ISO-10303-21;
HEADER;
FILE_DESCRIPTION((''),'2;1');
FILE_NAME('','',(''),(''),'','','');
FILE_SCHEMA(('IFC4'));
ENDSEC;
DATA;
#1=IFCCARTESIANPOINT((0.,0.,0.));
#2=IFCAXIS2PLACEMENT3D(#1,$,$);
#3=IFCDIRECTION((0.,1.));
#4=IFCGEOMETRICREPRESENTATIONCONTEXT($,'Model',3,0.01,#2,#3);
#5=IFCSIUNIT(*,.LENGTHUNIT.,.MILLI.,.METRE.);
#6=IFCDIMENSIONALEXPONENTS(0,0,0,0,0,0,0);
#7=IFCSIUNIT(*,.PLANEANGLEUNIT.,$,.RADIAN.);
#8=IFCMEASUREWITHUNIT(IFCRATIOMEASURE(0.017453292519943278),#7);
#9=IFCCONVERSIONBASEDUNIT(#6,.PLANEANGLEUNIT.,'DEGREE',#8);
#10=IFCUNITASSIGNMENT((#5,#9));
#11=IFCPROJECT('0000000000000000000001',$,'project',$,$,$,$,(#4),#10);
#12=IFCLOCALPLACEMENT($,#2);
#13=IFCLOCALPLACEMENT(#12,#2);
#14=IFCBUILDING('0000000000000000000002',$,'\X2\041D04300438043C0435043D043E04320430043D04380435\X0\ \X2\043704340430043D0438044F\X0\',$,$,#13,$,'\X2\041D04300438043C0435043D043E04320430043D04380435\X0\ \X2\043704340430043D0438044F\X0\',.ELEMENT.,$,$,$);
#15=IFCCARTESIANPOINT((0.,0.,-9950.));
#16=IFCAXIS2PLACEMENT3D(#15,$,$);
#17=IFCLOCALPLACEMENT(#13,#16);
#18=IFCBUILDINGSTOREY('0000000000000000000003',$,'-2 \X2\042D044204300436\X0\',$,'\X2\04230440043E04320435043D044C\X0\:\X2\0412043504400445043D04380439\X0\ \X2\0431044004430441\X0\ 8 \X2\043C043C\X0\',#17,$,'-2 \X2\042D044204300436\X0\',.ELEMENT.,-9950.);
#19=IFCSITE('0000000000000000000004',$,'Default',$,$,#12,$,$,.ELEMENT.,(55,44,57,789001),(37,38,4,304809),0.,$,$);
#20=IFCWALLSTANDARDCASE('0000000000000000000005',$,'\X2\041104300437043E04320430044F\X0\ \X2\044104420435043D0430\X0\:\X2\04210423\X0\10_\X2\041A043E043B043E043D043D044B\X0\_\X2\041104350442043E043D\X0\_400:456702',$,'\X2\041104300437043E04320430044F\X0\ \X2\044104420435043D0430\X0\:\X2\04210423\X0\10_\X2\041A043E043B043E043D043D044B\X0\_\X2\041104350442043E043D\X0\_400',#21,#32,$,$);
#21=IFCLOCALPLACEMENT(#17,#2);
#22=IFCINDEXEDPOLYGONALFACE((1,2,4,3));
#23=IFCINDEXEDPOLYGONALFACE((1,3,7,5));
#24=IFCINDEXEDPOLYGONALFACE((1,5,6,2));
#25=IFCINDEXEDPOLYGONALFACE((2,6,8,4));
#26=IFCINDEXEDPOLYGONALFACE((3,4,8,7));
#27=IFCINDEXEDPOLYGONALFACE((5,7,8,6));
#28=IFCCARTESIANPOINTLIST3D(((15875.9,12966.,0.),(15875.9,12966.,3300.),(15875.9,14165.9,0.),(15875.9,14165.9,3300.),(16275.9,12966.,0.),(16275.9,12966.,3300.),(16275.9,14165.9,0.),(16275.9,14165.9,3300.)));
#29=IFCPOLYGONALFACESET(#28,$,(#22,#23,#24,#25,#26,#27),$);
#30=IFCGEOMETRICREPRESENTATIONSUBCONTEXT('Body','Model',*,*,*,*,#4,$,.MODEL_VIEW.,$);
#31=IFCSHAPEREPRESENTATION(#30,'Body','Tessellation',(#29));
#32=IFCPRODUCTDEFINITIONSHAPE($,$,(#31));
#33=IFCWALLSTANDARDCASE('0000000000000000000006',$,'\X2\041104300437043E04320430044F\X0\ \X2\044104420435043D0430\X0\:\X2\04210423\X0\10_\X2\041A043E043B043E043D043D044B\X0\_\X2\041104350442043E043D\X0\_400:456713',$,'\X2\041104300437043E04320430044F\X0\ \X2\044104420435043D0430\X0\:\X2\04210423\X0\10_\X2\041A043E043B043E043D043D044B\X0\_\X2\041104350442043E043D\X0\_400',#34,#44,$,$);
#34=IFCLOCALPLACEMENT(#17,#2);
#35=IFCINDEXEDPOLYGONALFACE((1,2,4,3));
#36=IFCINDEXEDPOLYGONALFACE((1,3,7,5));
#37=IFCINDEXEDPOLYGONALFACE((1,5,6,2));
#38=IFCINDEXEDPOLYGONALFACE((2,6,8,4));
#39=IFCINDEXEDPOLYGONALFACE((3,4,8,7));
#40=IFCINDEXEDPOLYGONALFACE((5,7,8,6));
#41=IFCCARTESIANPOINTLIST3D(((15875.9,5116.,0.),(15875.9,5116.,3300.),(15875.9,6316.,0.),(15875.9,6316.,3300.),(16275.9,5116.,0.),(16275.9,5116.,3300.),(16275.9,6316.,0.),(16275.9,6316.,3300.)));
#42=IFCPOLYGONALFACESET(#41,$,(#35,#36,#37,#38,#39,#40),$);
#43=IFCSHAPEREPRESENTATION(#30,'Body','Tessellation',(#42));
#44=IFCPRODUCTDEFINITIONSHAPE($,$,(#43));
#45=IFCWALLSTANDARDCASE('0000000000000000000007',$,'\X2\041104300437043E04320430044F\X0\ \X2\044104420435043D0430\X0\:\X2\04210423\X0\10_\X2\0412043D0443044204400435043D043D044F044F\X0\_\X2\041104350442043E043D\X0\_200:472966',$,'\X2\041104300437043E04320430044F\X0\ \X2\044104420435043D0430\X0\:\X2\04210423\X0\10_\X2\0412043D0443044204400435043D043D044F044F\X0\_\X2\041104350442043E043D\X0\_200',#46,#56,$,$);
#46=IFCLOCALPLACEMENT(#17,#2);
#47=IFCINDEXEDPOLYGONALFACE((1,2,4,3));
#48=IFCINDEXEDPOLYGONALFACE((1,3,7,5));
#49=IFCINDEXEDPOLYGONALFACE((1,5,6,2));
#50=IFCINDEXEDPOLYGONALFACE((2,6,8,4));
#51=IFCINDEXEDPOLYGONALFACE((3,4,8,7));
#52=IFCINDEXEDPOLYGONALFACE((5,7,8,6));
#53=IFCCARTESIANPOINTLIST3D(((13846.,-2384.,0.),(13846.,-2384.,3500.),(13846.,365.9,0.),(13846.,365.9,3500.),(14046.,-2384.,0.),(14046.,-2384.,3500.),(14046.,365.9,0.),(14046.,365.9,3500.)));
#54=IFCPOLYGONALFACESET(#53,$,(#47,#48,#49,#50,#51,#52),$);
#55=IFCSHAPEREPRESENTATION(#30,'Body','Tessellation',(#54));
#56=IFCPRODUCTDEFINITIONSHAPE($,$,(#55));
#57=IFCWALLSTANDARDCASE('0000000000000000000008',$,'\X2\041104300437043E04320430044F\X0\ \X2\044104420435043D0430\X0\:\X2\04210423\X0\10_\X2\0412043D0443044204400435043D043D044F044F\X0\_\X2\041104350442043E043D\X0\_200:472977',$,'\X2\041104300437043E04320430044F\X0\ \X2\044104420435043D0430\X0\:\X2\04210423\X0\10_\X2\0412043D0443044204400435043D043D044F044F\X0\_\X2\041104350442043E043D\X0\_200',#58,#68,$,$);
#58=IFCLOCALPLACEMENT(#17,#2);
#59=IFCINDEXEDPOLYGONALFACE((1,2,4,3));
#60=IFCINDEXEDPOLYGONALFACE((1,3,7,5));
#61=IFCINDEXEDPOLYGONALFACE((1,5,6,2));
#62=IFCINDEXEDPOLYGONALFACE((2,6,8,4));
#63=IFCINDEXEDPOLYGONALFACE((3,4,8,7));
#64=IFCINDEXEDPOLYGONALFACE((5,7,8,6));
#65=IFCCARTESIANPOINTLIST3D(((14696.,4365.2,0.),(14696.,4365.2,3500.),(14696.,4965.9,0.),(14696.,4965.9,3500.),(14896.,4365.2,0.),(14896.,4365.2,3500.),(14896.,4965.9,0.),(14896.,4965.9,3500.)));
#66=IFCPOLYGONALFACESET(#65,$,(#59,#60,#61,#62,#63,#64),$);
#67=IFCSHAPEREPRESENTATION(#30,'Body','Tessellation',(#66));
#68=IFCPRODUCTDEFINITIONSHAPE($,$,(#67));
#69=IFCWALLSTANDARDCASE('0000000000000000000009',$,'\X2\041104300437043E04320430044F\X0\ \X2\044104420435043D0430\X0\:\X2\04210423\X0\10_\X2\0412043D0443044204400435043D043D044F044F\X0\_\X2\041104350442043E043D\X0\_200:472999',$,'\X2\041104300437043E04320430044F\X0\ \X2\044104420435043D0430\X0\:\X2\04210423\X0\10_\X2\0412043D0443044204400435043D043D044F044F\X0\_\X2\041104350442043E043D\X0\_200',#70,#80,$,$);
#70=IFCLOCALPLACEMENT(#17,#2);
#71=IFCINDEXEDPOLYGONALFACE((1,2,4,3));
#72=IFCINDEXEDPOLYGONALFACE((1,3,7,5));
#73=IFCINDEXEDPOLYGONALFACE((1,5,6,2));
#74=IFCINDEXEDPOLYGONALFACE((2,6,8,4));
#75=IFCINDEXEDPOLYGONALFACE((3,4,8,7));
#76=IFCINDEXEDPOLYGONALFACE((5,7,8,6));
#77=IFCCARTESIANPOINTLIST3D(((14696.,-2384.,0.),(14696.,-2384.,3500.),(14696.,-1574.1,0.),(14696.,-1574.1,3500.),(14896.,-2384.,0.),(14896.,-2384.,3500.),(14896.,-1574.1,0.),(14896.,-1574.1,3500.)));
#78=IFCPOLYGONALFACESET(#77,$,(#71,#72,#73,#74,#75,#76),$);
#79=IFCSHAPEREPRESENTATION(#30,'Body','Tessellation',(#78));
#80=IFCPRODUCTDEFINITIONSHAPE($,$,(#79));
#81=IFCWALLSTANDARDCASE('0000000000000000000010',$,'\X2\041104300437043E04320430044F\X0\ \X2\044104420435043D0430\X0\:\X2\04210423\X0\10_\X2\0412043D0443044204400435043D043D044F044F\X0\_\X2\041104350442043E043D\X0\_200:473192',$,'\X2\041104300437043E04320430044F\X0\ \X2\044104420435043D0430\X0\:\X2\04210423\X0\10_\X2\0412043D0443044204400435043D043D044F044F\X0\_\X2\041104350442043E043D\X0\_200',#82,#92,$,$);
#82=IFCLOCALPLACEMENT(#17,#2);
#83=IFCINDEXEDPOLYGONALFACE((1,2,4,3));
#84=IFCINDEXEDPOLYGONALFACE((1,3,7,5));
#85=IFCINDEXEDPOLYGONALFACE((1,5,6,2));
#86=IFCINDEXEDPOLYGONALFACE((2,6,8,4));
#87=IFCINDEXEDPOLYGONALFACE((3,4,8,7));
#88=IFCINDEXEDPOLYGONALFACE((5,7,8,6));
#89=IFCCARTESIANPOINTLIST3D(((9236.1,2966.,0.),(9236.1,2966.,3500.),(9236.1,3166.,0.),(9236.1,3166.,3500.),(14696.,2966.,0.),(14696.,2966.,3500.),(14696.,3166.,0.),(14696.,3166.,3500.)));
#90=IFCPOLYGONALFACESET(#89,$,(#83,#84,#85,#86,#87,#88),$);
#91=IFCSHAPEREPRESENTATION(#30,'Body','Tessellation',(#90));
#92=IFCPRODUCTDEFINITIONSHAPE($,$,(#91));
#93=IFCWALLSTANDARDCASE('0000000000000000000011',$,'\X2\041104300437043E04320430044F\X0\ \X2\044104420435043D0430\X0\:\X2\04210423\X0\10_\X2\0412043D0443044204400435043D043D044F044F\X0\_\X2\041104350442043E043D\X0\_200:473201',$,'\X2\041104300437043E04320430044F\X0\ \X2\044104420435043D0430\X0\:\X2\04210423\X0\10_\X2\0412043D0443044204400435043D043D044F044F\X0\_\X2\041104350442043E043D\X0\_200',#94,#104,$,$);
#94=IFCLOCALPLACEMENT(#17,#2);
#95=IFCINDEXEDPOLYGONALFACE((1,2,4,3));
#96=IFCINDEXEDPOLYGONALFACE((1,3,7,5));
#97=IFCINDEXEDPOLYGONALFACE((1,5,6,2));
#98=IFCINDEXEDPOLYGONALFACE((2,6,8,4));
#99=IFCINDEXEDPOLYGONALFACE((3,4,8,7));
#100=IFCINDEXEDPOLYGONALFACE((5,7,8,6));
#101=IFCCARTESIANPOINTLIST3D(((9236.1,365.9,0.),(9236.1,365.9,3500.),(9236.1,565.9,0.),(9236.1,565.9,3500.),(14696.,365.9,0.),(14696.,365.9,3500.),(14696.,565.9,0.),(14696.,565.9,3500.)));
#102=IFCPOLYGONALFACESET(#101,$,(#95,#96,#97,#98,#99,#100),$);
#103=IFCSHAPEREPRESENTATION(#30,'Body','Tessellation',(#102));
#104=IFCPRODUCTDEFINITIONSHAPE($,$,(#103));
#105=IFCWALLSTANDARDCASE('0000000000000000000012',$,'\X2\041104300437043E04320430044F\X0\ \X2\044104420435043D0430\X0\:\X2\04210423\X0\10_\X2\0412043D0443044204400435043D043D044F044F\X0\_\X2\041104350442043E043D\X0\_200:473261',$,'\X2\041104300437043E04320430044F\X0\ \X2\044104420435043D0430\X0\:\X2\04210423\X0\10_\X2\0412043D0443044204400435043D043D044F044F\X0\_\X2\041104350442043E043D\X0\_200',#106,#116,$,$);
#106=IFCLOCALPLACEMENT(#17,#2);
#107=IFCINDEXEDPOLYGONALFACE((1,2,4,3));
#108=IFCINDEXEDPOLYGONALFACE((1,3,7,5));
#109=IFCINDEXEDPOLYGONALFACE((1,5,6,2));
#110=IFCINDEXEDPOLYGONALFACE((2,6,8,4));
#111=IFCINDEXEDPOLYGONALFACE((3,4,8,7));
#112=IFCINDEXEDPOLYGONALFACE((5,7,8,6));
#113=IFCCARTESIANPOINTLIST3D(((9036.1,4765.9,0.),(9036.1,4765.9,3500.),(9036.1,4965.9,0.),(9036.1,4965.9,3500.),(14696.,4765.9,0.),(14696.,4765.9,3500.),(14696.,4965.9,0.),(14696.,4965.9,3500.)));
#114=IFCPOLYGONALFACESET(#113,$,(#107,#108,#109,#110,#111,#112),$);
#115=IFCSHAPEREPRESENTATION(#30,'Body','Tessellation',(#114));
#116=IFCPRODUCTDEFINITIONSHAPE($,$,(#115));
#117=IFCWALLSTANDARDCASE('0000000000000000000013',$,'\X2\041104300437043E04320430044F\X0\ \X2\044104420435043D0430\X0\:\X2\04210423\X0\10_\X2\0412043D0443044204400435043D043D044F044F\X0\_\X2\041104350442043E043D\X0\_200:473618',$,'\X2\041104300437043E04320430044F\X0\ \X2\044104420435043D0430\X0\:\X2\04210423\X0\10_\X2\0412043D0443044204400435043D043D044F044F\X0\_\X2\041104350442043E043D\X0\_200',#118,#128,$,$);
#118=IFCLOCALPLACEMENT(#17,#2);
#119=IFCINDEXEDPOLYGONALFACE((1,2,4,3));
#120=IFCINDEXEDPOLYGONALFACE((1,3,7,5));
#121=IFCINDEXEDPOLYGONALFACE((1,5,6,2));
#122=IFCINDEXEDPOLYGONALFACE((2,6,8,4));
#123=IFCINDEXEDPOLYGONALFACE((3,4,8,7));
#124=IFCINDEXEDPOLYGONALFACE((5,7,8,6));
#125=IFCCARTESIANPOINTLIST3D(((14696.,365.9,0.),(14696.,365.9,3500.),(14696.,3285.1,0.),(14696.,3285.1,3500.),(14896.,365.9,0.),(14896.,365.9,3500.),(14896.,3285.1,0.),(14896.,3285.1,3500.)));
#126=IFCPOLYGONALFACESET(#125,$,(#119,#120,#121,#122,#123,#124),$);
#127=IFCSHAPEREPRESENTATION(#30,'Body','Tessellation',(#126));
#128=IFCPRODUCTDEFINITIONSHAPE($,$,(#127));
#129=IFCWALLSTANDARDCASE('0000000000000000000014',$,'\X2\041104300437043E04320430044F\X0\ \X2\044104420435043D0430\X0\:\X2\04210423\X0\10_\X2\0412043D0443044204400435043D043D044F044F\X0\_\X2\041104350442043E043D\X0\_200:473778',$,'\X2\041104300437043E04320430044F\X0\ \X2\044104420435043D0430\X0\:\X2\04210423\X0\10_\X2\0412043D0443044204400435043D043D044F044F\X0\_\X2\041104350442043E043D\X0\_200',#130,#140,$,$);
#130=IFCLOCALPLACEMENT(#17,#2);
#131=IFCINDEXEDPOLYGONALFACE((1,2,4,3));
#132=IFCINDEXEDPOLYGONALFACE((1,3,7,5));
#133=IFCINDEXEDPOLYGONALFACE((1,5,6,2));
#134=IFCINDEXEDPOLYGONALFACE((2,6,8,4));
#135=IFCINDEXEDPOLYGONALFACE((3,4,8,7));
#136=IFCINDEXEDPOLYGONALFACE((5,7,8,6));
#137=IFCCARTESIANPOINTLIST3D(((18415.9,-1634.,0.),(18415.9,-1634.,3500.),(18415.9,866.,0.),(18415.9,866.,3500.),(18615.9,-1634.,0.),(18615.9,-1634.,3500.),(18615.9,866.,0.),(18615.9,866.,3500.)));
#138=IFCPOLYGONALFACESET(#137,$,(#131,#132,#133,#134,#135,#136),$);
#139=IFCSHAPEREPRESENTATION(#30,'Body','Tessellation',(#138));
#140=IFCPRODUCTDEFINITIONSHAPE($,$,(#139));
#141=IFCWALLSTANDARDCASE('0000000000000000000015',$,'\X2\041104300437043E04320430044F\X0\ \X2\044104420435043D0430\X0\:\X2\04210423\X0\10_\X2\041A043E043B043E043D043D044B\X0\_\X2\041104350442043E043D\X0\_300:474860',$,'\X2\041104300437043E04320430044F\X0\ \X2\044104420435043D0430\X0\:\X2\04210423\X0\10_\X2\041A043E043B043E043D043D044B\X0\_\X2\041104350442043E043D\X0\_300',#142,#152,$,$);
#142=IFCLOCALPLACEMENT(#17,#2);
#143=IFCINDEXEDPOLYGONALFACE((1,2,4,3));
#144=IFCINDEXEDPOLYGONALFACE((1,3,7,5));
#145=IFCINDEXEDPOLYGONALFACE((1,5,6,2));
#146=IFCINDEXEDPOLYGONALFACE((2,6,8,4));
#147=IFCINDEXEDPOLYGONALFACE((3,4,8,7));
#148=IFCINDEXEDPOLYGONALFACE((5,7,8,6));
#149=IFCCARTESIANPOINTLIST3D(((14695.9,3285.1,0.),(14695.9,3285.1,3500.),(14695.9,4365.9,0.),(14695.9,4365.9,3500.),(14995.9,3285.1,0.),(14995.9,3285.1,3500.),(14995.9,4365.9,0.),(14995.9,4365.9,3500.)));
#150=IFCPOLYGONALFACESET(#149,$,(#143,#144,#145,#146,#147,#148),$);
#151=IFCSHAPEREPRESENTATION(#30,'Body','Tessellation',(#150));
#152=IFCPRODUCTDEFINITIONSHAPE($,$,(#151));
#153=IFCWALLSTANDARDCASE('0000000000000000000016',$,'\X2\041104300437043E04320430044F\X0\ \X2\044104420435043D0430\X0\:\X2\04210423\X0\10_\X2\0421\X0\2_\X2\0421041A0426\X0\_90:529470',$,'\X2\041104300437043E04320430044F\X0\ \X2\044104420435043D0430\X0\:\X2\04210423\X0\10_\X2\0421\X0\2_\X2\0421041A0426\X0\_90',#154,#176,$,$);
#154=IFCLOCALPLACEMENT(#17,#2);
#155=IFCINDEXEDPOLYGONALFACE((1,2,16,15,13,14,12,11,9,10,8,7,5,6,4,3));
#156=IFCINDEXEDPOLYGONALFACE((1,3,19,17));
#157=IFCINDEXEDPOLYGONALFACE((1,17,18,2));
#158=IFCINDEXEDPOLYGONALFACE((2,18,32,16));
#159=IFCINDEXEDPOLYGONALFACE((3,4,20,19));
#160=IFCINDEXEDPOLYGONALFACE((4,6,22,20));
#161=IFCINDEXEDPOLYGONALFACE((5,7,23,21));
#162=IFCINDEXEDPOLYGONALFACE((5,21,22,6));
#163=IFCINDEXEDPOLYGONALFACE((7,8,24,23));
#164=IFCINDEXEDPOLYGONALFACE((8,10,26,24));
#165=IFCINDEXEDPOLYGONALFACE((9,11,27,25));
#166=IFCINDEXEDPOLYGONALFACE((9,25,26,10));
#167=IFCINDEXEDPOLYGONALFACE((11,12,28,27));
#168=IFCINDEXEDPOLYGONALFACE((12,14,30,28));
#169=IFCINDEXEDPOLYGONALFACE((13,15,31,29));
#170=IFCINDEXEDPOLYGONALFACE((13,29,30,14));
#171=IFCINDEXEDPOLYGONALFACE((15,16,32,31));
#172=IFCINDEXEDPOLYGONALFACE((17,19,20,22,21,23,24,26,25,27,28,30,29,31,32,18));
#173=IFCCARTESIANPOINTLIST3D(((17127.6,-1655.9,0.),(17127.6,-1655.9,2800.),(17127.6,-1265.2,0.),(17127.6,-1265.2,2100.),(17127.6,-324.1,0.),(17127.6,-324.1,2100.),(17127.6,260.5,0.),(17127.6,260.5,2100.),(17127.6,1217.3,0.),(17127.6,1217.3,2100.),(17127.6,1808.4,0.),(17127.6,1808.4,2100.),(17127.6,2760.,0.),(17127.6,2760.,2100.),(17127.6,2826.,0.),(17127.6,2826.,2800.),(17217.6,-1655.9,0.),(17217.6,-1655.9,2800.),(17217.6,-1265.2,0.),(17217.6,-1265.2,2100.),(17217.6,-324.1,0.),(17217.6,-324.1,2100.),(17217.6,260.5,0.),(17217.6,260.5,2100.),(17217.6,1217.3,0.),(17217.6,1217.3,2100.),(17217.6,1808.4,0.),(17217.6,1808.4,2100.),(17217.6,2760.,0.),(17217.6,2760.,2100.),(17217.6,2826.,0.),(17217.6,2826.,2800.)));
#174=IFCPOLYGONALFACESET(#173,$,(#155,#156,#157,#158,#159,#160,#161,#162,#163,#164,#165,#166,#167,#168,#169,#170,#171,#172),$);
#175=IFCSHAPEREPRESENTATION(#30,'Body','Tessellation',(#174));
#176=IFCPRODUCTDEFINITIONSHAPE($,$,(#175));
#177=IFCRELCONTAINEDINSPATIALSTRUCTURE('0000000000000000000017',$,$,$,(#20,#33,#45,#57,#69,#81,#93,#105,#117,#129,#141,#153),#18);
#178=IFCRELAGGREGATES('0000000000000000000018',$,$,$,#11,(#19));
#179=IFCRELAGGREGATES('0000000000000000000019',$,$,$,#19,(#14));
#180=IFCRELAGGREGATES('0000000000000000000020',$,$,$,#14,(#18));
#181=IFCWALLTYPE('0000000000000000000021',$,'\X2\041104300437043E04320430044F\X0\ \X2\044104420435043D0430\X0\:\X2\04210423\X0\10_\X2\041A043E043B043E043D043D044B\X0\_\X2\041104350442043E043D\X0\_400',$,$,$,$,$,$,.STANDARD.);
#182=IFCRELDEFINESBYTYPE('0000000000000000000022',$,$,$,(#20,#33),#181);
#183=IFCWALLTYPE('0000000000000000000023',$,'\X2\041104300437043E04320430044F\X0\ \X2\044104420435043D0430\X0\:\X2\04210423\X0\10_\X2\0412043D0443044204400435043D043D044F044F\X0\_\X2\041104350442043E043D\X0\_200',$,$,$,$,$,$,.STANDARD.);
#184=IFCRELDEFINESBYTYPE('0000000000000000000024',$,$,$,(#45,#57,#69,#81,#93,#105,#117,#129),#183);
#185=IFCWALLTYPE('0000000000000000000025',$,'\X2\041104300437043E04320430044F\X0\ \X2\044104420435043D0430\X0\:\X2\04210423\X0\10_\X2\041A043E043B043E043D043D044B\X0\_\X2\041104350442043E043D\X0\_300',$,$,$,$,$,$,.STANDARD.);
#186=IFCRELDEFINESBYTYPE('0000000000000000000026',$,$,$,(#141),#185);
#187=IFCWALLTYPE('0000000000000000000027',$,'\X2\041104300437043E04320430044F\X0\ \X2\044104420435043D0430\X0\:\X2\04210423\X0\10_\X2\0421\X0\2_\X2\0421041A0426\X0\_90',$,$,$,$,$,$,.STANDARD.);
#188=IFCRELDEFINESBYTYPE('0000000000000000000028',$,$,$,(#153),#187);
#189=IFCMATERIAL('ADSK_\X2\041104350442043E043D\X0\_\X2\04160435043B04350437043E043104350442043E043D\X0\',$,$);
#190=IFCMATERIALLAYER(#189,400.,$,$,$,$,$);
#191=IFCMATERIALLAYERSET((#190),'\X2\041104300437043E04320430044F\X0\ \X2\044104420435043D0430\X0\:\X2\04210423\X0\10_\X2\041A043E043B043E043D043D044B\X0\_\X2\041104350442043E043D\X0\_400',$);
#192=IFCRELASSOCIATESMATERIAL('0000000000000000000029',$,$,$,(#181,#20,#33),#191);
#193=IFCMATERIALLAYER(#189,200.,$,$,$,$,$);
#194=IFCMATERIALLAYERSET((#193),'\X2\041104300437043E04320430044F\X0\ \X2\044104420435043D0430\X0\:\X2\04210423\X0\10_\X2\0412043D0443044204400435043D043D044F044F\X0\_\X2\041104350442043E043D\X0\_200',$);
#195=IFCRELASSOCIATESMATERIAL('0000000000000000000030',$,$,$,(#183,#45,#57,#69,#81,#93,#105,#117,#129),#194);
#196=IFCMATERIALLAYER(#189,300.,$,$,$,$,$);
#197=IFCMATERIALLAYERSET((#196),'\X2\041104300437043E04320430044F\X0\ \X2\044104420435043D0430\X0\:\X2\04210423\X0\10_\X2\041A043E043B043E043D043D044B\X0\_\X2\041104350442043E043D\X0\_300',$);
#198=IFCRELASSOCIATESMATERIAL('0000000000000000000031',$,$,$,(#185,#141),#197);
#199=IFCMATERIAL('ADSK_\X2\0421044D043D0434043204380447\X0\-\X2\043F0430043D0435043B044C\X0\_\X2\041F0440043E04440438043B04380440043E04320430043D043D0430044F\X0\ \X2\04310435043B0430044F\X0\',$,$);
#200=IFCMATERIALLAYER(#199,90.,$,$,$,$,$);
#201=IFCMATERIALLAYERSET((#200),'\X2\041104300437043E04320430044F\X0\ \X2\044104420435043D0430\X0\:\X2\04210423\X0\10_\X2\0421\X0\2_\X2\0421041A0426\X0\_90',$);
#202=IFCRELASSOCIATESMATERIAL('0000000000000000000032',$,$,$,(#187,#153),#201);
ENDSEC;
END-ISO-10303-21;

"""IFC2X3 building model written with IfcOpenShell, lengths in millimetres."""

from ifc_helpers import new_model, entity, si_unit, converted_unit, direction, frame, frame_2d, origin, place, context, subcontext, project, spatial, rectangle, extrude, material, layer, layer_set, layer_usage, type_object, element, save


model = new_model("IFC2X3")

# Units and contexts
model_context = context("Model", 3, precision=0.01, world=origin(), true_north=direction((0.0, 1.0)))
body_context = subcontext(model_context, "Body", "Model", "MODEL_VIEW")
ifc_project = project(units=[si_unit("LENGTHUNIT", "METRE", prefix="MILLI"), converted_unit("PLANEANGLEUNIT", "DEGREE", entity("IfcRatioMeasure", 0.017453292519943278), si_unit("PLANEANGLEUNIT", "RADIAN"), dimensions=[0, 0, 0, 0, 0, 0, 0])], contexts=[model_context])

# Site, building, storey
site_placement = place(None, origin())
site = spatial("IfcSite", under=ifc_project, at=site_placement, Name="Default", CompositionType="ELEMENT", RefLatitude=(55, 44, 57, 789001), RefLongitude=(37, 38, 4, 304809), RefElevation=0.0)
building_placement = place(site_placement, origin())
building = spatial("IfcBuilding", under=site, at=building_placement, Name="Наименование здания", LongName="Наименование здания", CompositionType="ELEMENT")
storey_placement = place(building_placement, frame((0.0, 0.0, -9950.0)))
storey = spatial("IfcBuildingStorey", under=building, at=storey_placement, Name="-2 Этаж", ObjectType="Уровень:Верхний брус 8 мм", LongName="-2 Этаж", CompositionType="ELEMENT", Elevation=-9950.0)

# Walls
ifc_material_1 = material(Name="ADSK_Бетон_Железобетон")
ifc_layer_1 = layer(ifc_material_1, 400.0)
ifc_layer_set_1 = layer_set([ifc_layer_1], Name="Базовая стена:СУ10_Колонны_Бетон_400")
ifc_layer_usage_1 = layer_usage(ifc_layer_set_1, "AXIS2", "NEGATIVE", 200.0)
wall_type_1 = type_object("IfcWallType", Name="Базовая стена:СУ10_Колонны_Бетон_400", PredefinedType="STANDARD", material=ifc_layer_set_1)
for number, where, z_axis, x_axis, name in (
    (1, (16075.9, 12966.0, 0.0), (0.0, 0.0, 1.0), (0.0, 1.0, 0.0), "Базовая стена:СУ10_Колонны_Бетон_400:456702"),
    (2, (16075.9, 5116.0, 0.0), (0.0, 0.0, 1.0), (0.0, 1.0, 0.0), "Базовая стена:СУ10_Колонны_Бетон_400:456713"),
):
    element("IfcWallStandardCase", number, at=place(storey_placement, frame(where, z_axis=z_axis, x_axis=x_axis)), inside=storey, type_object=wall_type_1, material=ifc_layer_usage_1, Name=name, ObjectType="Базовая стена:СУ10_Колонны_Бетон_400", context=body_context, shape_type="SweptSolid", body=[
        extrude(rectangle(XDim=1200.0, YDim=400.0, at=frame_2d((600.0, 0.0), x_axis=(-1.0, 0.0))), origin(), (0.0, 0.0, 1.0), 3300.0),
    ])
ifc_layer_2 = layer(ifc_material_1, 200.0)
ifc_layer_set_2 = layer_set([ifc_layer_2], Name="Базовая стена:СУ10_Внутренняя_Бетон_200")
ifc_layer_usage_2 = layer_usage(ifc_layer_set_2, "AXIS2", "NEGATIVE", 100.0)
wall_type_2 = type_object("IfcWallType", Name="Базовая стена:СУ10_Внутренняя_Бетон_200", PredefinedType="STANDARD", material=ifc_layer_set_2)
wall_1_placement = place(storey_placement, frame((13946.0, 365.9, 0.0), z_axis=(0.0, 0.0, 1.0), x_axis=(0.0, -1.0, 0.0)))
element("IfcWallStandardCase", 3, at=wall_1_placement, inside=storey, type_object=wall_type_2, material=ifc_layer_usage_2, Name="Базовая стена:СУ10_Внутренняя_Бетон_200:472966", ObjectType="Базовая стена:СУ10_Внутренняя_Бетон_200", context=body_context, shape_type="SweptSolid", body=[
    extrude(rectangle(XDim=2749.9, YDim=200.0, at=frame_2d((1375.0, 0.0), x_axis=(-1.0, 0.0))), origin(), (0.0, 0.0, 1.0), 3500.0),
])
wall_2_placement = place(storey_placement, frame((14796.0, 4965.9, 0.0), z_axis=(0.0, 0.0, 1.0), x_axis=(0.0, -1.0, 0.0)))
element("IfcWallStandardCase", 4, at=wall_2_placement, inside=storey, type_object=wall_type_2, material=ifc_layer_usage_2, Name="Базовая стена:СУ10_Внутренняя_Бетон_200:472977", ObjectType="Базовая стена:СУ10_Внутренняя_Бетон_200", context=body_context, shape_type="SweptSolid", body=[
    extrude(rectangle(XDim=600.7, YDim=200.0, at=frame_2d((300.4, 0.0), x_axis=(-1.0, 0.0))), origin(), (0.0, 0.0, 1.0), 3500.0),
])
wall_3_placement = place(storey_placement, frame((14796.0, -1574.1, 0.0), z_axis=(0.0, 0.0, 1.0), x_axis=(0.0, -1.0, 0.0)))
element("IfcWallStandardCase", 5, at=wall_3_placement, inside=storey, type_object=wall_type_2, material=ifc_layer_usage_2, Name="Базовая стена:СУ10_Внутренняя_Бетон_200:472999", ObjectType="Базовая стена:СУ10_Внутренняя_Бетон_200", context=body_context, shape_type="SweptSolid", body=[
    extrude(rectangle(XDim=809.9, YDim=200.0, at=frame_2d((405.0, 0.0), x_axis=(-1.0, 0.0))), origin(), (0.0, 0.0, 1.0), 3500.0),
])
wall_4_placement = place(storey_placement, frame((14696.0, 3066.0, 0.0), z_axis=(0.0, 0.0, 1.0), x_axis=(-1.0, 0.0, 0.0)))
element("IfcWallStandardCase", 6, at=wall_4_placement, inside=storey, type_object=wall_type_2, material=ifc_layer_usage_2, Name="Базовая стена:СУ10_Внутренняя_Бетон_200:473192", ObjectType="Базовая стена:СУ10_Внутренняя_Бетон_200", context=body_context, shape_type="SweptSolid", body=[
    extrude(rectangle(XDim=5459.9, YDim=200.0, at=frame_2d((2729.9, 0.0), x_axis=(-1.0, 0.0))), origin(), (0.0, 0.0, 1.0), 3500.0),
])
wall_5_placement = place(storey_placement, frame((14696.0, 465.9, 0.0), z_axis=(0.0, 0.0, 1.0), x_axis=(-1.0, 0.0, 0.0)))
element("IfcWallStandardCase", 7, at=wall_5_placement, inside=storey, type_object=wall_type_2, material=ifc_layer_usage_2, Name="Базовая стена:СУ10_Внутренняя_Бетон_200:473201", ObjectType="Базовая стена:СУ10_Внутренняя_Бетон_200", context=body_context, shape_type="SweptSolid", body=[
    extrude(rectangle(XDim=5459.9, YDim=200.0, at=frame_2d((2729.9, 0.0), x_axis=(-1.0, 0.0))), origin(), (0.0, 0.0, 1.0), 3500.0),
])
wall_6_placement = place(storey_placement, frame((14696.0, 4865.9, 0.0), z_axis=(0.0, 0.0, 1.0), x_axis=(-1.0, 0.0, 0.0)))
element("IfcWallStandardCase", 8, at=wall_6_placement, inside=storey, type_object=wall_type_2, material=ifc_layer_usage_2, Name="Базовая стена:СУ10_Внутренняя_Бетон_200:473261", ObjectType="Базовая стена:СУ10_Внутренняя_Бетон_200", context=body_context, shape_type="SweptSolid", body=[
    extrude(rectangle(XDim=5659.9, YDim=200.0, at=frame_2d((2829.9, 0.0), x_axis=(-1.0, 0.0))), origin(), (0.0, 0.0, 1.0), 3500.0),
])
wall_7_placement = place(storey_placement, frame((14796.0, 3285.1, 0.0), z_axis=(0.0, 0.0, 1.0), x_axis=(0.0, -1.0, 0.0)))
element("IfcWallStandardCase", 9, at=wall_7_placement, inside=storey, type_object=wall_type_2, material=ifc_layer_usage_2, Name="Базовая стена:СУ10_Внутренняя_Бетон_200:473618", ObjectType="Базовая стена:СУ10_Внутренняя_Бетон_200", context=body_context, shape_type="SweptSolid", body=[
    extrude(rectangle(XDim=2919.2, YDim=200.0, at=frame_2d((1459.6, 0.0), x_axis=(-1.0, 0.0))), origin(), (0.0, 0.0, 1.0), 3500.0),
])
wall_8_placement = place(storey_placement, frame((18515.9, 866.0, 0.0), z_axis=(0.0, 0.0, 1.0), x_axis=(0.0, -1.0, 0.0)))
element("IfcWallStandardCase", 10, at=wall_8_placement, inside=storey, type_object=wall_type_2, material=ifc_layer_usage_2, Name="Базовая стена:СУ10_Внутренняя_Бетон_200:473778", ObjectType="Базовая стена:СУ10_Внутренняя_Бетон_200", context=body_context, shape_type="SweptSolid", body=[
    extrude(rectangle(XDim=2500.0, YDim=200.0, at=frame_2d((1250.0, 0.0), x_axis=(-1.0, 0.0))), origin(), (0.0, 0.0, 1.0), 3500.0),
])
ifc_layer_3 = layer(ifc_material_1, 300.0)
ifc_layer_set_3 = layer_set([ifc_layer_3], Name="Базовая стена:СУ10_Колонны_Бетон_300")
ifc_layer_usage_3 = layer_usage(ifc_layer_set_3, "AXIS2", "NEGATIVE", 150.0)
wall_type_3 = type_object("IfcWallType", Name="Базовая стена:СУ10_Колонны_Бетон_300", PredefinedType="STANDARD", material=ifc_layer_set_3)
wall_9_placement = place(storey_placement, frame((14845.9, 3285.1, 0.0), z_axis=(0.0, 0.0, 1.0), x_axis=(0.0, 1.0, 0.0)))
element("IfcWallStandardCase", 11, at=wall_9_placement, inside=storey, type_object=wall_type_3, material=ifc_layer_usage_3, Name="Базовая стена:СУ10_Колонны_Бетон_300:474860", ObjectType="Базовая стена:СУ10_Колонны_Бетон_300", context=body_context, shape_type="SweptSolid", body=[
    extrude(rectangle(XDim=1080.8, YDim=300.0, at=frame_2d((540.4, 0.0), x_axis=(-1.0, 0.0))), origin(), (0.0, 0.0, 1.0), 3500.0),
])

# Wall, openings
ifc_material_2 = material(Name="ADSK_Сэндвич-панель_Профилированная белая")
ifc_layer_4 = layer(ifc_material_2, 90.0)
ifc_layer_set_4 = layer_set([ifc_layer_4], Name="Базовая стена:СУ10_С2_СКЦ_90")
ifc_layer_usage_4 = layer_usage(ifc_layer_set_4, "AXIS2", "NEGATIVE", 45.0)
wall_type_4 = type_object("IfcWallType", Name="Базовая стена:СУ10_С2_СКЦ_90", PredefinedType="STANDARD", material=ifc_layer_set_4)
wall_10_placement = place(storey_placement, frame((17172.6, 2826.0, 0.0), z_axis=(0.0, 0.0, 1.0), x_axis=(0.0, -1.0, 0.0)))
wall_10 = element("IfcWallStandardCase", 12, at=wall_10_placement, inside=storey, type_object=wall_type_4, material=ifc_layer_usage_4, Name="Базовая стена:СУ10_С2_СКЦ_90:529470", ObjectType="Базовая стена:СУ10_С2_СКЦ_90", context=body_context, shape_type="SweptSolid", body=[
    extrude(rectangle(XDim=4481.9, YDim=90.0, at=frame_2d((2240.9, 0.0), x_axis=(-1.0, 0.0))), origin(), (0.0, 0.0, 1.0), 2800.0),
])
opening_1_placement = place(wall_10_placement, origin())
element("IfcOpeningElement", 13, at=opening_1_placement, cuts=wall_10, ObjectType="Opening", context=body_context, shape_type="SweptSolid", body=[
    extrude(rectangle(XDim=2100.0, YDim=941.1, at=frame_2d((0.0, 0.0), x_axis=(1.0, 0.0))), frame((3620.6, -45.0, 1050.0), z_axis=(0.0, 1.0, 0.0), x_axis=(0.0, 0.0, -1.0)), (0.0, 0.0, 1.0), 90.0),
])
opening_2_placement = place(wall_10_placement, origin())
element("IfcOpeningElement", 14, at=opening_2_placement, cuts=wall_10, ObjectType="Opening", context=body_context, shape_type="SweptSolid", body=[
    extrude(rectangle(XDim=2100.0, YDim=956.8, at=frame_2d((0.0, 0.0), x_axis=(1.0, 0.0))), frame((2087.1, -45.0, 1050.0), z_axis=(0.0, 1.0, 0.0), x_axis=(0.0, 0.0, -1.0)), (0.0, 0.0, 1.0), 90.0),
])
opening_3_placement = place(wall_10_placement, origin())
element("IfcOpeningElement", 15, at=opening_3_placement, cuts=wall_10, ObjectType="Opening", context=body_context, shape_type="SweptSolid", body=[
    extrude(rectangle(XDim=2100.0, YDim=951.5, at=frame_2d((0.0, 0.0), x_axis=(1.0, 0.0))), frame((541.8, -45.0, 1050.0), z_axis=(0.0, 1.0, 0.0), x_axis=(0.0, 0.0, -1.0)), (0.0, 0.0, 1.0), 90.0),
])

save(model, "model.ifc")
